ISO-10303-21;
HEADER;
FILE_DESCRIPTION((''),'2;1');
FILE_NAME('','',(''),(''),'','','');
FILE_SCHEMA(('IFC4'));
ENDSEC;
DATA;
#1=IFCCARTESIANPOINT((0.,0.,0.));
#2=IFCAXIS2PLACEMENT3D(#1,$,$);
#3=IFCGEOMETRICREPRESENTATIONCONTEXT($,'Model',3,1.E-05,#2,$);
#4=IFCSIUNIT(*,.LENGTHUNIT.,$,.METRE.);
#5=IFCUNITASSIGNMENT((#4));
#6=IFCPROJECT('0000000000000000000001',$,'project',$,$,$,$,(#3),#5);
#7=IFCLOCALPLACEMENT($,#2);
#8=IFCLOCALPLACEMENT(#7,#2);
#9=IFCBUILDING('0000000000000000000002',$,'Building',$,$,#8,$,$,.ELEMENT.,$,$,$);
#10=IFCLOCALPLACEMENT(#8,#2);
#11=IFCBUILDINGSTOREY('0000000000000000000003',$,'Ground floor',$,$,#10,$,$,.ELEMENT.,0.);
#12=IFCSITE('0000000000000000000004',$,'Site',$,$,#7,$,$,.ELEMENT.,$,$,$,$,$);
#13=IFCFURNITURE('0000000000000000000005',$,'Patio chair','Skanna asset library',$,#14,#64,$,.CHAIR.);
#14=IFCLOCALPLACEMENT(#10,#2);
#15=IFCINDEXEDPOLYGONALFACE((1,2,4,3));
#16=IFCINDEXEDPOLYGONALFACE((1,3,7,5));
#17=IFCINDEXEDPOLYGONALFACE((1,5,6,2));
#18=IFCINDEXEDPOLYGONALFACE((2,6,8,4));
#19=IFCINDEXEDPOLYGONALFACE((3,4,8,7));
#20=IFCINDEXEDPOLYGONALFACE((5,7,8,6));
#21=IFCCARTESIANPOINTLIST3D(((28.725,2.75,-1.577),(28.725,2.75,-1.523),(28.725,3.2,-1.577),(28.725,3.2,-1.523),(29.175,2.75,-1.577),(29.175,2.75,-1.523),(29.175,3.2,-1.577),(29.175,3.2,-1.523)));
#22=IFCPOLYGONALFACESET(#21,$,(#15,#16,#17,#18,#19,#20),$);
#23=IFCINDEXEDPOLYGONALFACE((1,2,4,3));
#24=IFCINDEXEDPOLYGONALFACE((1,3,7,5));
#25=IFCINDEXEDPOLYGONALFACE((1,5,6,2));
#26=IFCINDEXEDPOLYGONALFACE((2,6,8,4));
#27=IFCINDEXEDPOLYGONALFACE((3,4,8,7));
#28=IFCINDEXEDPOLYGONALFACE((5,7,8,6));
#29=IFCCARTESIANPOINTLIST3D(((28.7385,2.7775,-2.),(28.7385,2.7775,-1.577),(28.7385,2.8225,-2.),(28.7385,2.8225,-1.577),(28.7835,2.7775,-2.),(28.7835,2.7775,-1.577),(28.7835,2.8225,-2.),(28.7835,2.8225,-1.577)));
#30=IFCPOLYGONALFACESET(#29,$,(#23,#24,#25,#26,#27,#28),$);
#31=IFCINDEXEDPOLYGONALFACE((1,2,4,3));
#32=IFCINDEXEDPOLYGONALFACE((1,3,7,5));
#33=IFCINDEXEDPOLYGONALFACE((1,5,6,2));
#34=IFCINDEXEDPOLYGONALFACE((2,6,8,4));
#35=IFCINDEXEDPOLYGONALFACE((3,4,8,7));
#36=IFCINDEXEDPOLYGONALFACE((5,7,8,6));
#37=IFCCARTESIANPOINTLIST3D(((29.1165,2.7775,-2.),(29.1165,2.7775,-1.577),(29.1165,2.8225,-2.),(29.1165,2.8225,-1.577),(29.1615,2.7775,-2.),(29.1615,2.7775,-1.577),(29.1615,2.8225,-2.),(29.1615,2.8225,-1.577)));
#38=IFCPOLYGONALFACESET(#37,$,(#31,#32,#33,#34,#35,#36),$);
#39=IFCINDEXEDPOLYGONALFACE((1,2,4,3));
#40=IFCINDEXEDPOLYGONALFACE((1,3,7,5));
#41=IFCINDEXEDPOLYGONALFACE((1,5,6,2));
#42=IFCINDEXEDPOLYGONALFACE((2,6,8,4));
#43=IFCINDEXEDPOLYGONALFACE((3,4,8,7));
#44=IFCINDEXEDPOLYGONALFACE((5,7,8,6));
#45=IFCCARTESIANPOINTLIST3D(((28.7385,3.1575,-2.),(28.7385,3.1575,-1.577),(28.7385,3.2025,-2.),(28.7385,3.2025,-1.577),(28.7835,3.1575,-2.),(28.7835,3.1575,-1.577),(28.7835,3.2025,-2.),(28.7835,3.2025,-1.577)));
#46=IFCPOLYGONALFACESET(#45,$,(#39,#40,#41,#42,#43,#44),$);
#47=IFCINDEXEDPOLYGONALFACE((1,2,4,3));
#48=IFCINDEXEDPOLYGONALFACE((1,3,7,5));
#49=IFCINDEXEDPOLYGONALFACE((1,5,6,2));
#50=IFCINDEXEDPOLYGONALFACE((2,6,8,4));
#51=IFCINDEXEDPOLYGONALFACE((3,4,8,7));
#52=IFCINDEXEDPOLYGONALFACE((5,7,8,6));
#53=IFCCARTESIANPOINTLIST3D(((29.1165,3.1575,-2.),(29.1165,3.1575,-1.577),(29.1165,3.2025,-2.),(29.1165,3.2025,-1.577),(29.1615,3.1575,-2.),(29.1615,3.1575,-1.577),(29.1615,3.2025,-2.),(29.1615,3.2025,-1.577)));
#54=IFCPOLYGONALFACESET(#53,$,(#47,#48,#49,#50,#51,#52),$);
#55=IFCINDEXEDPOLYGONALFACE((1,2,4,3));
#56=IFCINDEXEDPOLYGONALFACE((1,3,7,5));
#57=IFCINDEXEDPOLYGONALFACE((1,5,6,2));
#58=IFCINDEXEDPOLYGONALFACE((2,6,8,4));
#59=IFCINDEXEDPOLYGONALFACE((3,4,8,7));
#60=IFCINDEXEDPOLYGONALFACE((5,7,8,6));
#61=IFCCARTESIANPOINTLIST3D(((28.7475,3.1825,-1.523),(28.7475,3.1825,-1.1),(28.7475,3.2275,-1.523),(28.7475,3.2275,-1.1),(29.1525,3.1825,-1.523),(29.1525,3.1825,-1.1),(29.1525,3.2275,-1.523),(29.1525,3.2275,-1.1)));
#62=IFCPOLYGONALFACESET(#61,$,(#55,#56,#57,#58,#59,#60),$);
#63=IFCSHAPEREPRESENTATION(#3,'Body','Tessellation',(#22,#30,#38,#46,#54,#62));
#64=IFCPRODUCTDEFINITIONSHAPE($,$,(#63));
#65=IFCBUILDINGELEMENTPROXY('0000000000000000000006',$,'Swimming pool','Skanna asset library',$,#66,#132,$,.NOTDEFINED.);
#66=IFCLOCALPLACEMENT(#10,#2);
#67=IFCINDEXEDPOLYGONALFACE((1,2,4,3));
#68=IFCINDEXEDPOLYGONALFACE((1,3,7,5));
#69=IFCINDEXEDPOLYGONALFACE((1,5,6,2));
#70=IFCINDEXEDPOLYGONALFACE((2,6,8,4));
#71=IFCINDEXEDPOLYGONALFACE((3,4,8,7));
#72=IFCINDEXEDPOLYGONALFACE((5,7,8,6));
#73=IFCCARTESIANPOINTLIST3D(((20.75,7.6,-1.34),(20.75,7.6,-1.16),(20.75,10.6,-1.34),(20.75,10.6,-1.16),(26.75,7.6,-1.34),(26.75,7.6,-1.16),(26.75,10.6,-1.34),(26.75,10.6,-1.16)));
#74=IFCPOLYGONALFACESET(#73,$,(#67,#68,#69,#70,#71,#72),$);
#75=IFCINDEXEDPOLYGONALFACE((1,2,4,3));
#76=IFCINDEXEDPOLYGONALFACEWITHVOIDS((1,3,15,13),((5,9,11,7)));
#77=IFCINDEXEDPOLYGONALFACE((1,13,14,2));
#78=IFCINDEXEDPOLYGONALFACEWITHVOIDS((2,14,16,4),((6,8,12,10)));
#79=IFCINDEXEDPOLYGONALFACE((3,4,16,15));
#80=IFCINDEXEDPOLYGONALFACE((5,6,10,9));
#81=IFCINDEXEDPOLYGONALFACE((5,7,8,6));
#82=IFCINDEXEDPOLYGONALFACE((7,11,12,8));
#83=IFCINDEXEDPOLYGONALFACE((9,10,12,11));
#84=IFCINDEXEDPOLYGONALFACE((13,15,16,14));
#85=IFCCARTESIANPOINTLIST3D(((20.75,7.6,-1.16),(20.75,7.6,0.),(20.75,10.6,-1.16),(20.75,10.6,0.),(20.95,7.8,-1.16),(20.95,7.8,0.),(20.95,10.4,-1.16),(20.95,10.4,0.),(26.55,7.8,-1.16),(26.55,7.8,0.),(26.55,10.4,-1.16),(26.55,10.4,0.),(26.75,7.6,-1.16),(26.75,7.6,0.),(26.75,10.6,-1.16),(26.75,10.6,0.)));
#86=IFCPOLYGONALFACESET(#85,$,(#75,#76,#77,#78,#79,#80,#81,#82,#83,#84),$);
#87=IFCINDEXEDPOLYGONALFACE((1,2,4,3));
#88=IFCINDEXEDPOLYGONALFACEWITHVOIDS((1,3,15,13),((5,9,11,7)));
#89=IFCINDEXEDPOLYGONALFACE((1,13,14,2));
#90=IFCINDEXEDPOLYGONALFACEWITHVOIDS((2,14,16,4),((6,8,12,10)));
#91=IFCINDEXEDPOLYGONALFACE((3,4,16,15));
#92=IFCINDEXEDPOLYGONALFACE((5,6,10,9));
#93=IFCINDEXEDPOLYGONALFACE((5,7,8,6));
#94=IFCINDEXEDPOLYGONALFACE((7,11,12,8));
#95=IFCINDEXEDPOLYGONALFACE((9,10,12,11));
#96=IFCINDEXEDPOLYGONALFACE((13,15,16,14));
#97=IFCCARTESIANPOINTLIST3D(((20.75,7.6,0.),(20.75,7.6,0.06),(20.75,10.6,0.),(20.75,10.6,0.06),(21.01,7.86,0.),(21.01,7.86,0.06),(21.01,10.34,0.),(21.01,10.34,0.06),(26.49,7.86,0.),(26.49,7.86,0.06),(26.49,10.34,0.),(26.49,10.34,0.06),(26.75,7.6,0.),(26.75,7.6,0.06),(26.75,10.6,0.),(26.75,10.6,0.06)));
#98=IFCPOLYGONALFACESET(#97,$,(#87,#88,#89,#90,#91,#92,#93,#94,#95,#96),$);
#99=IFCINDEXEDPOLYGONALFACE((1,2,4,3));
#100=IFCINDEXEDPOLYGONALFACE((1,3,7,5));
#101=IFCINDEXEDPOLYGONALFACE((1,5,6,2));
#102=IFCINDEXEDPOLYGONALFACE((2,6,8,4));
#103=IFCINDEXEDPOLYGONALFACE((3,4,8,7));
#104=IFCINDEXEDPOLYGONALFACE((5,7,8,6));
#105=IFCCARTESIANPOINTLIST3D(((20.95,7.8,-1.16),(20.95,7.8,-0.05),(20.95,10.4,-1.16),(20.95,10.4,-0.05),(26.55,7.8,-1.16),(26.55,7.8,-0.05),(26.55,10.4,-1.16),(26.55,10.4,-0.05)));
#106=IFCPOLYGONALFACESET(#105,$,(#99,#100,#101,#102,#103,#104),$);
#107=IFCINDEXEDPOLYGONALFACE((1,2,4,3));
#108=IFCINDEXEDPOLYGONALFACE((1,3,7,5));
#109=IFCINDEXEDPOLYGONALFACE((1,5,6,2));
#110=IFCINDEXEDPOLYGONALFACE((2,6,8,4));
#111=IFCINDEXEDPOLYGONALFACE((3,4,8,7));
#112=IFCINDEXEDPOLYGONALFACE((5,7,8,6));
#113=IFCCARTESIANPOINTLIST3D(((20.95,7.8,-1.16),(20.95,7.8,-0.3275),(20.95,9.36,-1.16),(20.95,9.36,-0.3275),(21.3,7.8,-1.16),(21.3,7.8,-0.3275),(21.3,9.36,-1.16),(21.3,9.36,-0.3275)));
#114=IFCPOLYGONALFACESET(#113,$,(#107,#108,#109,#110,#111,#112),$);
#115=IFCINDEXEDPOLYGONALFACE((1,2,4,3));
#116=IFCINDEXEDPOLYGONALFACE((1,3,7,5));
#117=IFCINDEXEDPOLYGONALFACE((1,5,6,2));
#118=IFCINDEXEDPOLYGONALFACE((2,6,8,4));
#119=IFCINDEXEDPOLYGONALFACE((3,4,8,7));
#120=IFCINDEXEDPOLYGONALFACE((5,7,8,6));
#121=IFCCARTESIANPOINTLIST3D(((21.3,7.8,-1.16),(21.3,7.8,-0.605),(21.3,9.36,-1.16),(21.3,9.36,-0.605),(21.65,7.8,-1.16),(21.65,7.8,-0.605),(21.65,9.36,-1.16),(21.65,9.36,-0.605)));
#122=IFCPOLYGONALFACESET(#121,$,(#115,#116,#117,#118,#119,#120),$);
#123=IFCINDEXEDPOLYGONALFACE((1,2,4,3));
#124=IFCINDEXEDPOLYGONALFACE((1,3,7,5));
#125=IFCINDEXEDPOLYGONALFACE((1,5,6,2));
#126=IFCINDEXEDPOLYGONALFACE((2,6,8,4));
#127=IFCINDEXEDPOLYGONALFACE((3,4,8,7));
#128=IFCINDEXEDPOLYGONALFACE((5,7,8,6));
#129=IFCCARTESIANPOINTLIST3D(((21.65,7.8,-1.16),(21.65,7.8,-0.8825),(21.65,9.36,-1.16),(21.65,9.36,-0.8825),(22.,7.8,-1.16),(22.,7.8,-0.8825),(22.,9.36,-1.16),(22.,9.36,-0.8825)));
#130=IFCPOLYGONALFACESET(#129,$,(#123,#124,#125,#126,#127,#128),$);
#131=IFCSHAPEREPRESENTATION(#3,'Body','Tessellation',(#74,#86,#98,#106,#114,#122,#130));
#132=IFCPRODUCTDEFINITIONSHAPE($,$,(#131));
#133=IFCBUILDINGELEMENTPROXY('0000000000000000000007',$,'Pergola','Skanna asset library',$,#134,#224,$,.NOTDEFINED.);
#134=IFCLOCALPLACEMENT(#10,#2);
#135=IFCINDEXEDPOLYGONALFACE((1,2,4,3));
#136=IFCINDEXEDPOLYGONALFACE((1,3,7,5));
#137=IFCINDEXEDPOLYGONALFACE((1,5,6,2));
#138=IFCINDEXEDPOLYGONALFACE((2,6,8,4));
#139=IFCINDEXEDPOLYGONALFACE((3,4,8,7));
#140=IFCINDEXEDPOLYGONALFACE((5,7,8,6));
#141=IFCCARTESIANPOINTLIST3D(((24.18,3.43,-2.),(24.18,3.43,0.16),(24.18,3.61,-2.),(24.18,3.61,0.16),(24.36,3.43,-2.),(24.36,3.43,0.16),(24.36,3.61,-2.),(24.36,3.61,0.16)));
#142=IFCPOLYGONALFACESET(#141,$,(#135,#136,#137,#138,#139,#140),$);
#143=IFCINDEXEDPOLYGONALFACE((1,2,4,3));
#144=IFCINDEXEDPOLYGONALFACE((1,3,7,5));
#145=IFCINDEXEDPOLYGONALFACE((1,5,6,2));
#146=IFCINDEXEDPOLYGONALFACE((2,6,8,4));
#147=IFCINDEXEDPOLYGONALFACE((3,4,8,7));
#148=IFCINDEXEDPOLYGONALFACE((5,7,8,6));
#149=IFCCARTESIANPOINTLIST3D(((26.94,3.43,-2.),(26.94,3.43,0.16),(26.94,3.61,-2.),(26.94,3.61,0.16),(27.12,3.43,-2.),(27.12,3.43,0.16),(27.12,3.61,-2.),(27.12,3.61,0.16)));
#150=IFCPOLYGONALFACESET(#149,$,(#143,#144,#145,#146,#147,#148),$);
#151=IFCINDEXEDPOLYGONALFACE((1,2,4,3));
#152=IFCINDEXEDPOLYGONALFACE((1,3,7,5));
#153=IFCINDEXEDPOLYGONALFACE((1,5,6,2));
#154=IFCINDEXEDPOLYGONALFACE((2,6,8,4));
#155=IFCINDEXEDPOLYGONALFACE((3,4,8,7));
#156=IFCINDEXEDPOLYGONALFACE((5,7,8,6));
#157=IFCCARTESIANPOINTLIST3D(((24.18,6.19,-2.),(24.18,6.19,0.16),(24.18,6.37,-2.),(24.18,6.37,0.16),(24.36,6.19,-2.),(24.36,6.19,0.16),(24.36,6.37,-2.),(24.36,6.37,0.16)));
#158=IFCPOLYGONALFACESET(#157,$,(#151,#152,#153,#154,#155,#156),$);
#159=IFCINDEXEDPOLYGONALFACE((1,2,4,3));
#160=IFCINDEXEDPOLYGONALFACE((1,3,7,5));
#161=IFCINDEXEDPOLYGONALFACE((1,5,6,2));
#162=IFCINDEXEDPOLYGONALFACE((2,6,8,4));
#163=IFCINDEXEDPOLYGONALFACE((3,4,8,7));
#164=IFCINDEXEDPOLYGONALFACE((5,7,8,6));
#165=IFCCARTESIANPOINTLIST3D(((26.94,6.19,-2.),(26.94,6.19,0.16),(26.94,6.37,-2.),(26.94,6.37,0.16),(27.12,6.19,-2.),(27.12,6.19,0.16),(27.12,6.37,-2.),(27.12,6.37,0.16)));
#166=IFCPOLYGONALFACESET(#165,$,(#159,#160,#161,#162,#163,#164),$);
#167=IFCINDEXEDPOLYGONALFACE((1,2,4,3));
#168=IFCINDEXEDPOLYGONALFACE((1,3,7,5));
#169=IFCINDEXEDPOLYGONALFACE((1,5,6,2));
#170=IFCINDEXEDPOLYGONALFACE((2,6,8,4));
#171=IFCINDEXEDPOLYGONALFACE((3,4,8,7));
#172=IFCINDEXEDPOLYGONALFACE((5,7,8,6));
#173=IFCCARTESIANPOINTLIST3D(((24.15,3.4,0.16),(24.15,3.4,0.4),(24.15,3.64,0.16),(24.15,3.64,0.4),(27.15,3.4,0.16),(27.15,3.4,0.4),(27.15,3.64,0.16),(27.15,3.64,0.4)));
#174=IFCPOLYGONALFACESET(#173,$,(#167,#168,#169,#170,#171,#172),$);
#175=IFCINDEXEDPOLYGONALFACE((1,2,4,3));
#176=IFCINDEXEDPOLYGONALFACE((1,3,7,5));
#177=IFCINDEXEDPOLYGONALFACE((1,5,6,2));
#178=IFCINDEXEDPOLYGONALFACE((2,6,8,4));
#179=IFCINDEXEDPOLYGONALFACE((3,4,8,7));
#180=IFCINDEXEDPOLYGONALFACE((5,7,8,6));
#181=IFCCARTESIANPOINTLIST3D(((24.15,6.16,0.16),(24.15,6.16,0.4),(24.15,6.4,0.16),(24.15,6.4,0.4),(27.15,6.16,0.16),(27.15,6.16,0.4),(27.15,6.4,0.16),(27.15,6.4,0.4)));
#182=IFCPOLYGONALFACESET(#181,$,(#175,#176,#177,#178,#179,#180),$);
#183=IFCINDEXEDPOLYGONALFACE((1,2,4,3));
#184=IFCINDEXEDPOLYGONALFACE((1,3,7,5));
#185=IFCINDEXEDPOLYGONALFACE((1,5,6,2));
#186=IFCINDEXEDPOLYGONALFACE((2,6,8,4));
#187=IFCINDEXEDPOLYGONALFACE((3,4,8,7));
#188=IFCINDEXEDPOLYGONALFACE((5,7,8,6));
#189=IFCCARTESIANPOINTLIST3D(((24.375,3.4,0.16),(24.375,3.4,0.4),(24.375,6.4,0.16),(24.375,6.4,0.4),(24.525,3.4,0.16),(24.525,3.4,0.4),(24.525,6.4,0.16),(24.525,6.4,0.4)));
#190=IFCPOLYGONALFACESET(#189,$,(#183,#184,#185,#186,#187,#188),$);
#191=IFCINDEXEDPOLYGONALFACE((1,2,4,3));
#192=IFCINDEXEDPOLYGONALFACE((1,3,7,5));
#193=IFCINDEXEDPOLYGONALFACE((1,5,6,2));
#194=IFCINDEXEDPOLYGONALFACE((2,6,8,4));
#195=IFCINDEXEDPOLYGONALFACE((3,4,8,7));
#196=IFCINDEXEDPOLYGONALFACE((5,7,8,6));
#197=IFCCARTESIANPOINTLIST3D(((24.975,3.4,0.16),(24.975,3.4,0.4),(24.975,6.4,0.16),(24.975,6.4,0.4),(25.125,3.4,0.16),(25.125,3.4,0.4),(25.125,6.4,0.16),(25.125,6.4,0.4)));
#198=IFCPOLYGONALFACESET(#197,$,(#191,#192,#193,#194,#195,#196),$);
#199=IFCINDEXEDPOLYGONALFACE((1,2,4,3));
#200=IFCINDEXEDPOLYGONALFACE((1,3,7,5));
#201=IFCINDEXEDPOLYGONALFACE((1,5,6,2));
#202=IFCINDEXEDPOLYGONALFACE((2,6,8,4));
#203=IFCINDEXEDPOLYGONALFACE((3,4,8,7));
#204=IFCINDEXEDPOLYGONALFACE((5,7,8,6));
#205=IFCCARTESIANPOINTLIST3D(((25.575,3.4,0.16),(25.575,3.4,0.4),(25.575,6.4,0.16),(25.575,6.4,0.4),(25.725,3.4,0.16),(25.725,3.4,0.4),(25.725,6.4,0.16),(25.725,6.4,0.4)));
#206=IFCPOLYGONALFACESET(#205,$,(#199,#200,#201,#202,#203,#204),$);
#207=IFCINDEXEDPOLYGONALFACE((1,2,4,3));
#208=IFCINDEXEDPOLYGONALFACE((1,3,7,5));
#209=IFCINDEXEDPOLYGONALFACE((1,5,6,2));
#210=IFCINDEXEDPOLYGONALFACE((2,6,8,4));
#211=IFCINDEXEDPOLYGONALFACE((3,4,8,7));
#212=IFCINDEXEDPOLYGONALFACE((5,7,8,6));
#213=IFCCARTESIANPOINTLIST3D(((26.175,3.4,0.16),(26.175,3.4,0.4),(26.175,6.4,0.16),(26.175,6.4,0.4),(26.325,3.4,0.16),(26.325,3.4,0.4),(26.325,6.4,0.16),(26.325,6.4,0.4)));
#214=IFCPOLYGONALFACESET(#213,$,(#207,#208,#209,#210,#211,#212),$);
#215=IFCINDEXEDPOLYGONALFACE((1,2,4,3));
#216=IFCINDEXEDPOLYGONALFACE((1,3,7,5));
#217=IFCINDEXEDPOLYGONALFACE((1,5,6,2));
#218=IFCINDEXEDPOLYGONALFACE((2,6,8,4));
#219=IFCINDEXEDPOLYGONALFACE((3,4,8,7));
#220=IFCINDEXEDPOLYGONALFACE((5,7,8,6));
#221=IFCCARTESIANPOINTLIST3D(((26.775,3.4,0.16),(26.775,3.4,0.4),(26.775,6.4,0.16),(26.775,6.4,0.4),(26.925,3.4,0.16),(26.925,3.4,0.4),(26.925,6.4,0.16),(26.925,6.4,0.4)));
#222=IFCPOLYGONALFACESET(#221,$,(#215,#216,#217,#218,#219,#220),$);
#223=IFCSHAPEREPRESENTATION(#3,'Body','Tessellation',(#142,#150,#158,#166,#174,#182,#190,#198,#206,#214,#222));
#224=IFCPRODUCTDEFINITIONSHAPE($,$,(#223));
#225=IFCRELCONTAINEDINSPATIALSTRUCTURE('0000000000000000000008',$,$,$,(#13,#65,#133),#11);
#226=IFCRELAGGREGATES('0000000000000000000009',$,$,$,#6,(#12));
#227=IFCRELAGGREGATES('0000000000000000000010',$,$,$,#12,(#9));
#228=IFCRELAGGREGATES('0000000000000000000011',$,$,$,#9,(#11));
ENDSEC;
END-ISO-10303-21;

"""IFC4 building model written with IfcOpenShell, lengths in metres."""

from ifc_helpers import new_model, si_unit, frame, frame_2d, origin, origin_2d, place, context, project, spatial, polyline, rectangle, outline, extrude, element, save


model = new_model("IFC4")

# Units and contexts
model_context = context("Model", 3, precision=1e-05, world=origin())
ifc_project = project(units=[si_unit("LENGTHUNIT", "METRE")], contexts=[model_context])

# Site, building, storey
site_placement = place(None, origin())
site = spatial("IfcSite", under=ifc_project, at=site_placement, Name="Site", CompositionType="ELEMENT")
building_placement = place(site_placement, origin())
building = spatial("IfcBuilding", under=site, at=building_placement, Name="Building", CompositionType="ELEMENT")
storey_placement = place(building_placement, origin())
storey = spatial("IfcBuildingStorey", under=building, at=storey_placement, Name="Ground floor", CompositionType="ELEMENT", Elevation=0.0)

# Furniture
for number, where, z_axis, x_axis, name in (
    (1, (28.95, 3.0, -2.0), (0.0, 0.0, 1.0), (1.0, 0.0, 0.0), "Patio chair"),
):
    element("IfcFurniture", number, at=place(storey_placement, frame(where, z_axis=z_axis, x_axis=x_axis)), inside=storey, Name=name, Description="Skanna asset library", PredefinedType="CHAIR", context=model_context, shape_type="SweptSolid", body=[
        extrude(rectangle(XDim=0.45, YDim=0.45, at=frame_2d((0.0, -0.025))), frame((0.0, 0.0, 0.423)), (0.0, 0.0, 1.0), 0.054),
        extrude(rectangle(XDim=0.045, YDim=0.045, at=frame_2d((-0.189, -0.2))), origin(), (0.0, 0.0, 1.0), 0.423),
        extrude(rectangle(XDim=0.045, YDim=0.045, at=frame_2d((0.189, -0.2))), origin(), (0.0, 0.0, 1.0), 0.423),
        extrude(rectangle(XDim=0.045, YDim=0.045, at=frame_2d((-0.189, 0.18))), origin(), (0.0, 0.0, 1.0), 0.423),
        extrude(rectangle(XDim=0.045, YDim=0.045, at=frame_2d((0.189, 0.18))), origin(), (0.0, 0.0, 1.0), 0.423),
        extrude(rectangle(XDim=0.405, YDim=0.045, at=frame_2d((0.0, 0.205))), frame((0.0, 0.0, 0.477)), (0.0, 0.0, 1.0), 0.423),
    ])

# Building element proxies
proxy_1_placement = place(storey_placement, frame((23.75, 9.1, -1.34), z_axis=(0.0, 0.0, 1.0), x_axis=(1.0, 0.0, 0.0)))
element("IfcBuildingElementProxy", 2, at=proxy_1_placement, inside=storey, Name="Swimming pool", Description="Skanna asset library", PredefinedType="NOTDEFINED", context=model_context, shape_type="SweptSolid", body=[
    extrude(rectangle(XDim=6.0, YDim=3.0, at=origin_2d()), origin(), (0.0, 0.0, 1.0), 0.18),
    extrude(outline(polyline([(-3.0, -1.5), (3.0, -1.5), (3.0, 1.5), (-3.0, 1.5), (-3.0, -1.5)]), holes=[polyline([(-2.8, -1.3), (2.8, -1.3), (2.8, 1.3), (-2.8, 1.3), (-2.8, -1.3)])]), frame((0.0, 0.0, 0.18)), (0.0, 0.0, 1.0), 1.16),
    extrude(outline(polyline([(-3.0, -1.5), (3.0, -1.5), (3.0, 1.5), (-3.0, 1.5), (-3.0, -1.5)]), holes=[polyline([(-2.74, -1.24), (2.74, -1.24), (2.74, 1.24), (-2.74, 1.24), (-2.74, -1.24)])]), frame((0.0, 0.0, 1.34)), (0.0, 0.0, 1.0), 0.06),
    extrude(rectangle(XDim=5.6, YDim=2.6, at=origin_2d()), frame((0.0, 0.0, 0.18)), (0.0, 0.0, 1.0), 1.11),
    extrude(rectangle(XDim=0.35, YDim=1.56, at=frame_2d((-2.625, -0.52))), frame((0.0, 0.0, 0.18)), (0.0, 0.0, 1.0), 0.8325),
    extrude(rectangle(XDim=0.35, YDim=1.56, at=frame_2d((-2.275, -0.52))), frame((0.0, 0.0, 0.18)), (0.0, 0.0, 1.0), 0.555),
    extrude(rectangle(XDim=0.35, YDim=1.56, at=frame_2d((-1.925, -0.52))), frame((0.0, 0.0, 0.18)), (0.0, 0.0, 1.0), 0.2775),
])
proxy_2_placement = place(storey_placement, frame((25.65, 4.9, -2.0), z_axis=(0.0, 0.0, 1.0), x_axis=(1.0, 0.0, 0.0)))
element("IfcBuildingElementProxy", 3, at=proxy_2_placement, inside=storey, Name="Pergola", Description="Skanna asset library", PredefinedType="NOTDEFINED", context=model_context, shape_type="SweptSolid", body=[
    extrude(rectangle(XDim=0.18, YDim=0.18, at=frame_2d((-1.38, -1.38))), origin(), (0.0, 0.0, 1.0), 2.16),
    extrude(rectangle(XDim=0.18, YDim=0.18, at=frame_2d((1.38, -1.38))), origin(), (0.0, 0.0, 1.0), 2.16),
    extrude(rectangle(XDim=0.18, YDim=0.18, at=frame_2d((-1.38, 1.38))), origin(), (0.0, 0.0, 1.0), 2.16),
    extrude(rectangle(XDim=0.18, YDim=0.18, at=frame_2d((1.38, 1.38))), origin(), (0.0, 0.0, 1.0), 2.16),
    extrude(rectangle(XDim=3.0, YDim=0.24, at=frame_2d((0.0, -1.38))), frame((0.0, 0.0, 2.16)), (0.0, 0.0, 1.0), 0.24),
    extrude(rectangle(XDim=3.0, YDim=0.24, at=frame_2d((0.0, 1.38))), frame((0.0, 0.0, 2.16)), (0.0, 0.0, 1.0), 0.24),
    extrude(rectangle(XDim=0.15, YDim=3.0, at=frame_2d((-1.2, 0.0))), frame((0.0, 0.0, 2.16)), (0.0, 0.0, 1.0), 0.24),
    extrude(rectangle(XDim=0.15, YDim=3.0, at=frame_2d((-0.6, 0.0))), frame((0.0, 0.0, 2.16)), (0.0, 0.0, 1.0), 0.24),
    extrude(rectangle(XDim=0.15, YDim=3.0, at=origin_2d()), frame((0.0, 0.0, 2.16)), (0.0, 0.0, 1.0), 0.24),
    extrude(rectangle(XDim=0.15, YDim=3.0, at=frame_2d((0.6, 0.0))), frame((0.0, 0.0, 2.16)), (0.0, 0.0, 1.0), 0.24),
    extrude(rectangle(XDim=0.15, YDim=3.0, at=frame_2d((1.2, 0.0))), frame((0.0, 0.0, 2.16)), (0.0, 0.0, 1.0), 0.24),
])

save(model, "model.ifc")
